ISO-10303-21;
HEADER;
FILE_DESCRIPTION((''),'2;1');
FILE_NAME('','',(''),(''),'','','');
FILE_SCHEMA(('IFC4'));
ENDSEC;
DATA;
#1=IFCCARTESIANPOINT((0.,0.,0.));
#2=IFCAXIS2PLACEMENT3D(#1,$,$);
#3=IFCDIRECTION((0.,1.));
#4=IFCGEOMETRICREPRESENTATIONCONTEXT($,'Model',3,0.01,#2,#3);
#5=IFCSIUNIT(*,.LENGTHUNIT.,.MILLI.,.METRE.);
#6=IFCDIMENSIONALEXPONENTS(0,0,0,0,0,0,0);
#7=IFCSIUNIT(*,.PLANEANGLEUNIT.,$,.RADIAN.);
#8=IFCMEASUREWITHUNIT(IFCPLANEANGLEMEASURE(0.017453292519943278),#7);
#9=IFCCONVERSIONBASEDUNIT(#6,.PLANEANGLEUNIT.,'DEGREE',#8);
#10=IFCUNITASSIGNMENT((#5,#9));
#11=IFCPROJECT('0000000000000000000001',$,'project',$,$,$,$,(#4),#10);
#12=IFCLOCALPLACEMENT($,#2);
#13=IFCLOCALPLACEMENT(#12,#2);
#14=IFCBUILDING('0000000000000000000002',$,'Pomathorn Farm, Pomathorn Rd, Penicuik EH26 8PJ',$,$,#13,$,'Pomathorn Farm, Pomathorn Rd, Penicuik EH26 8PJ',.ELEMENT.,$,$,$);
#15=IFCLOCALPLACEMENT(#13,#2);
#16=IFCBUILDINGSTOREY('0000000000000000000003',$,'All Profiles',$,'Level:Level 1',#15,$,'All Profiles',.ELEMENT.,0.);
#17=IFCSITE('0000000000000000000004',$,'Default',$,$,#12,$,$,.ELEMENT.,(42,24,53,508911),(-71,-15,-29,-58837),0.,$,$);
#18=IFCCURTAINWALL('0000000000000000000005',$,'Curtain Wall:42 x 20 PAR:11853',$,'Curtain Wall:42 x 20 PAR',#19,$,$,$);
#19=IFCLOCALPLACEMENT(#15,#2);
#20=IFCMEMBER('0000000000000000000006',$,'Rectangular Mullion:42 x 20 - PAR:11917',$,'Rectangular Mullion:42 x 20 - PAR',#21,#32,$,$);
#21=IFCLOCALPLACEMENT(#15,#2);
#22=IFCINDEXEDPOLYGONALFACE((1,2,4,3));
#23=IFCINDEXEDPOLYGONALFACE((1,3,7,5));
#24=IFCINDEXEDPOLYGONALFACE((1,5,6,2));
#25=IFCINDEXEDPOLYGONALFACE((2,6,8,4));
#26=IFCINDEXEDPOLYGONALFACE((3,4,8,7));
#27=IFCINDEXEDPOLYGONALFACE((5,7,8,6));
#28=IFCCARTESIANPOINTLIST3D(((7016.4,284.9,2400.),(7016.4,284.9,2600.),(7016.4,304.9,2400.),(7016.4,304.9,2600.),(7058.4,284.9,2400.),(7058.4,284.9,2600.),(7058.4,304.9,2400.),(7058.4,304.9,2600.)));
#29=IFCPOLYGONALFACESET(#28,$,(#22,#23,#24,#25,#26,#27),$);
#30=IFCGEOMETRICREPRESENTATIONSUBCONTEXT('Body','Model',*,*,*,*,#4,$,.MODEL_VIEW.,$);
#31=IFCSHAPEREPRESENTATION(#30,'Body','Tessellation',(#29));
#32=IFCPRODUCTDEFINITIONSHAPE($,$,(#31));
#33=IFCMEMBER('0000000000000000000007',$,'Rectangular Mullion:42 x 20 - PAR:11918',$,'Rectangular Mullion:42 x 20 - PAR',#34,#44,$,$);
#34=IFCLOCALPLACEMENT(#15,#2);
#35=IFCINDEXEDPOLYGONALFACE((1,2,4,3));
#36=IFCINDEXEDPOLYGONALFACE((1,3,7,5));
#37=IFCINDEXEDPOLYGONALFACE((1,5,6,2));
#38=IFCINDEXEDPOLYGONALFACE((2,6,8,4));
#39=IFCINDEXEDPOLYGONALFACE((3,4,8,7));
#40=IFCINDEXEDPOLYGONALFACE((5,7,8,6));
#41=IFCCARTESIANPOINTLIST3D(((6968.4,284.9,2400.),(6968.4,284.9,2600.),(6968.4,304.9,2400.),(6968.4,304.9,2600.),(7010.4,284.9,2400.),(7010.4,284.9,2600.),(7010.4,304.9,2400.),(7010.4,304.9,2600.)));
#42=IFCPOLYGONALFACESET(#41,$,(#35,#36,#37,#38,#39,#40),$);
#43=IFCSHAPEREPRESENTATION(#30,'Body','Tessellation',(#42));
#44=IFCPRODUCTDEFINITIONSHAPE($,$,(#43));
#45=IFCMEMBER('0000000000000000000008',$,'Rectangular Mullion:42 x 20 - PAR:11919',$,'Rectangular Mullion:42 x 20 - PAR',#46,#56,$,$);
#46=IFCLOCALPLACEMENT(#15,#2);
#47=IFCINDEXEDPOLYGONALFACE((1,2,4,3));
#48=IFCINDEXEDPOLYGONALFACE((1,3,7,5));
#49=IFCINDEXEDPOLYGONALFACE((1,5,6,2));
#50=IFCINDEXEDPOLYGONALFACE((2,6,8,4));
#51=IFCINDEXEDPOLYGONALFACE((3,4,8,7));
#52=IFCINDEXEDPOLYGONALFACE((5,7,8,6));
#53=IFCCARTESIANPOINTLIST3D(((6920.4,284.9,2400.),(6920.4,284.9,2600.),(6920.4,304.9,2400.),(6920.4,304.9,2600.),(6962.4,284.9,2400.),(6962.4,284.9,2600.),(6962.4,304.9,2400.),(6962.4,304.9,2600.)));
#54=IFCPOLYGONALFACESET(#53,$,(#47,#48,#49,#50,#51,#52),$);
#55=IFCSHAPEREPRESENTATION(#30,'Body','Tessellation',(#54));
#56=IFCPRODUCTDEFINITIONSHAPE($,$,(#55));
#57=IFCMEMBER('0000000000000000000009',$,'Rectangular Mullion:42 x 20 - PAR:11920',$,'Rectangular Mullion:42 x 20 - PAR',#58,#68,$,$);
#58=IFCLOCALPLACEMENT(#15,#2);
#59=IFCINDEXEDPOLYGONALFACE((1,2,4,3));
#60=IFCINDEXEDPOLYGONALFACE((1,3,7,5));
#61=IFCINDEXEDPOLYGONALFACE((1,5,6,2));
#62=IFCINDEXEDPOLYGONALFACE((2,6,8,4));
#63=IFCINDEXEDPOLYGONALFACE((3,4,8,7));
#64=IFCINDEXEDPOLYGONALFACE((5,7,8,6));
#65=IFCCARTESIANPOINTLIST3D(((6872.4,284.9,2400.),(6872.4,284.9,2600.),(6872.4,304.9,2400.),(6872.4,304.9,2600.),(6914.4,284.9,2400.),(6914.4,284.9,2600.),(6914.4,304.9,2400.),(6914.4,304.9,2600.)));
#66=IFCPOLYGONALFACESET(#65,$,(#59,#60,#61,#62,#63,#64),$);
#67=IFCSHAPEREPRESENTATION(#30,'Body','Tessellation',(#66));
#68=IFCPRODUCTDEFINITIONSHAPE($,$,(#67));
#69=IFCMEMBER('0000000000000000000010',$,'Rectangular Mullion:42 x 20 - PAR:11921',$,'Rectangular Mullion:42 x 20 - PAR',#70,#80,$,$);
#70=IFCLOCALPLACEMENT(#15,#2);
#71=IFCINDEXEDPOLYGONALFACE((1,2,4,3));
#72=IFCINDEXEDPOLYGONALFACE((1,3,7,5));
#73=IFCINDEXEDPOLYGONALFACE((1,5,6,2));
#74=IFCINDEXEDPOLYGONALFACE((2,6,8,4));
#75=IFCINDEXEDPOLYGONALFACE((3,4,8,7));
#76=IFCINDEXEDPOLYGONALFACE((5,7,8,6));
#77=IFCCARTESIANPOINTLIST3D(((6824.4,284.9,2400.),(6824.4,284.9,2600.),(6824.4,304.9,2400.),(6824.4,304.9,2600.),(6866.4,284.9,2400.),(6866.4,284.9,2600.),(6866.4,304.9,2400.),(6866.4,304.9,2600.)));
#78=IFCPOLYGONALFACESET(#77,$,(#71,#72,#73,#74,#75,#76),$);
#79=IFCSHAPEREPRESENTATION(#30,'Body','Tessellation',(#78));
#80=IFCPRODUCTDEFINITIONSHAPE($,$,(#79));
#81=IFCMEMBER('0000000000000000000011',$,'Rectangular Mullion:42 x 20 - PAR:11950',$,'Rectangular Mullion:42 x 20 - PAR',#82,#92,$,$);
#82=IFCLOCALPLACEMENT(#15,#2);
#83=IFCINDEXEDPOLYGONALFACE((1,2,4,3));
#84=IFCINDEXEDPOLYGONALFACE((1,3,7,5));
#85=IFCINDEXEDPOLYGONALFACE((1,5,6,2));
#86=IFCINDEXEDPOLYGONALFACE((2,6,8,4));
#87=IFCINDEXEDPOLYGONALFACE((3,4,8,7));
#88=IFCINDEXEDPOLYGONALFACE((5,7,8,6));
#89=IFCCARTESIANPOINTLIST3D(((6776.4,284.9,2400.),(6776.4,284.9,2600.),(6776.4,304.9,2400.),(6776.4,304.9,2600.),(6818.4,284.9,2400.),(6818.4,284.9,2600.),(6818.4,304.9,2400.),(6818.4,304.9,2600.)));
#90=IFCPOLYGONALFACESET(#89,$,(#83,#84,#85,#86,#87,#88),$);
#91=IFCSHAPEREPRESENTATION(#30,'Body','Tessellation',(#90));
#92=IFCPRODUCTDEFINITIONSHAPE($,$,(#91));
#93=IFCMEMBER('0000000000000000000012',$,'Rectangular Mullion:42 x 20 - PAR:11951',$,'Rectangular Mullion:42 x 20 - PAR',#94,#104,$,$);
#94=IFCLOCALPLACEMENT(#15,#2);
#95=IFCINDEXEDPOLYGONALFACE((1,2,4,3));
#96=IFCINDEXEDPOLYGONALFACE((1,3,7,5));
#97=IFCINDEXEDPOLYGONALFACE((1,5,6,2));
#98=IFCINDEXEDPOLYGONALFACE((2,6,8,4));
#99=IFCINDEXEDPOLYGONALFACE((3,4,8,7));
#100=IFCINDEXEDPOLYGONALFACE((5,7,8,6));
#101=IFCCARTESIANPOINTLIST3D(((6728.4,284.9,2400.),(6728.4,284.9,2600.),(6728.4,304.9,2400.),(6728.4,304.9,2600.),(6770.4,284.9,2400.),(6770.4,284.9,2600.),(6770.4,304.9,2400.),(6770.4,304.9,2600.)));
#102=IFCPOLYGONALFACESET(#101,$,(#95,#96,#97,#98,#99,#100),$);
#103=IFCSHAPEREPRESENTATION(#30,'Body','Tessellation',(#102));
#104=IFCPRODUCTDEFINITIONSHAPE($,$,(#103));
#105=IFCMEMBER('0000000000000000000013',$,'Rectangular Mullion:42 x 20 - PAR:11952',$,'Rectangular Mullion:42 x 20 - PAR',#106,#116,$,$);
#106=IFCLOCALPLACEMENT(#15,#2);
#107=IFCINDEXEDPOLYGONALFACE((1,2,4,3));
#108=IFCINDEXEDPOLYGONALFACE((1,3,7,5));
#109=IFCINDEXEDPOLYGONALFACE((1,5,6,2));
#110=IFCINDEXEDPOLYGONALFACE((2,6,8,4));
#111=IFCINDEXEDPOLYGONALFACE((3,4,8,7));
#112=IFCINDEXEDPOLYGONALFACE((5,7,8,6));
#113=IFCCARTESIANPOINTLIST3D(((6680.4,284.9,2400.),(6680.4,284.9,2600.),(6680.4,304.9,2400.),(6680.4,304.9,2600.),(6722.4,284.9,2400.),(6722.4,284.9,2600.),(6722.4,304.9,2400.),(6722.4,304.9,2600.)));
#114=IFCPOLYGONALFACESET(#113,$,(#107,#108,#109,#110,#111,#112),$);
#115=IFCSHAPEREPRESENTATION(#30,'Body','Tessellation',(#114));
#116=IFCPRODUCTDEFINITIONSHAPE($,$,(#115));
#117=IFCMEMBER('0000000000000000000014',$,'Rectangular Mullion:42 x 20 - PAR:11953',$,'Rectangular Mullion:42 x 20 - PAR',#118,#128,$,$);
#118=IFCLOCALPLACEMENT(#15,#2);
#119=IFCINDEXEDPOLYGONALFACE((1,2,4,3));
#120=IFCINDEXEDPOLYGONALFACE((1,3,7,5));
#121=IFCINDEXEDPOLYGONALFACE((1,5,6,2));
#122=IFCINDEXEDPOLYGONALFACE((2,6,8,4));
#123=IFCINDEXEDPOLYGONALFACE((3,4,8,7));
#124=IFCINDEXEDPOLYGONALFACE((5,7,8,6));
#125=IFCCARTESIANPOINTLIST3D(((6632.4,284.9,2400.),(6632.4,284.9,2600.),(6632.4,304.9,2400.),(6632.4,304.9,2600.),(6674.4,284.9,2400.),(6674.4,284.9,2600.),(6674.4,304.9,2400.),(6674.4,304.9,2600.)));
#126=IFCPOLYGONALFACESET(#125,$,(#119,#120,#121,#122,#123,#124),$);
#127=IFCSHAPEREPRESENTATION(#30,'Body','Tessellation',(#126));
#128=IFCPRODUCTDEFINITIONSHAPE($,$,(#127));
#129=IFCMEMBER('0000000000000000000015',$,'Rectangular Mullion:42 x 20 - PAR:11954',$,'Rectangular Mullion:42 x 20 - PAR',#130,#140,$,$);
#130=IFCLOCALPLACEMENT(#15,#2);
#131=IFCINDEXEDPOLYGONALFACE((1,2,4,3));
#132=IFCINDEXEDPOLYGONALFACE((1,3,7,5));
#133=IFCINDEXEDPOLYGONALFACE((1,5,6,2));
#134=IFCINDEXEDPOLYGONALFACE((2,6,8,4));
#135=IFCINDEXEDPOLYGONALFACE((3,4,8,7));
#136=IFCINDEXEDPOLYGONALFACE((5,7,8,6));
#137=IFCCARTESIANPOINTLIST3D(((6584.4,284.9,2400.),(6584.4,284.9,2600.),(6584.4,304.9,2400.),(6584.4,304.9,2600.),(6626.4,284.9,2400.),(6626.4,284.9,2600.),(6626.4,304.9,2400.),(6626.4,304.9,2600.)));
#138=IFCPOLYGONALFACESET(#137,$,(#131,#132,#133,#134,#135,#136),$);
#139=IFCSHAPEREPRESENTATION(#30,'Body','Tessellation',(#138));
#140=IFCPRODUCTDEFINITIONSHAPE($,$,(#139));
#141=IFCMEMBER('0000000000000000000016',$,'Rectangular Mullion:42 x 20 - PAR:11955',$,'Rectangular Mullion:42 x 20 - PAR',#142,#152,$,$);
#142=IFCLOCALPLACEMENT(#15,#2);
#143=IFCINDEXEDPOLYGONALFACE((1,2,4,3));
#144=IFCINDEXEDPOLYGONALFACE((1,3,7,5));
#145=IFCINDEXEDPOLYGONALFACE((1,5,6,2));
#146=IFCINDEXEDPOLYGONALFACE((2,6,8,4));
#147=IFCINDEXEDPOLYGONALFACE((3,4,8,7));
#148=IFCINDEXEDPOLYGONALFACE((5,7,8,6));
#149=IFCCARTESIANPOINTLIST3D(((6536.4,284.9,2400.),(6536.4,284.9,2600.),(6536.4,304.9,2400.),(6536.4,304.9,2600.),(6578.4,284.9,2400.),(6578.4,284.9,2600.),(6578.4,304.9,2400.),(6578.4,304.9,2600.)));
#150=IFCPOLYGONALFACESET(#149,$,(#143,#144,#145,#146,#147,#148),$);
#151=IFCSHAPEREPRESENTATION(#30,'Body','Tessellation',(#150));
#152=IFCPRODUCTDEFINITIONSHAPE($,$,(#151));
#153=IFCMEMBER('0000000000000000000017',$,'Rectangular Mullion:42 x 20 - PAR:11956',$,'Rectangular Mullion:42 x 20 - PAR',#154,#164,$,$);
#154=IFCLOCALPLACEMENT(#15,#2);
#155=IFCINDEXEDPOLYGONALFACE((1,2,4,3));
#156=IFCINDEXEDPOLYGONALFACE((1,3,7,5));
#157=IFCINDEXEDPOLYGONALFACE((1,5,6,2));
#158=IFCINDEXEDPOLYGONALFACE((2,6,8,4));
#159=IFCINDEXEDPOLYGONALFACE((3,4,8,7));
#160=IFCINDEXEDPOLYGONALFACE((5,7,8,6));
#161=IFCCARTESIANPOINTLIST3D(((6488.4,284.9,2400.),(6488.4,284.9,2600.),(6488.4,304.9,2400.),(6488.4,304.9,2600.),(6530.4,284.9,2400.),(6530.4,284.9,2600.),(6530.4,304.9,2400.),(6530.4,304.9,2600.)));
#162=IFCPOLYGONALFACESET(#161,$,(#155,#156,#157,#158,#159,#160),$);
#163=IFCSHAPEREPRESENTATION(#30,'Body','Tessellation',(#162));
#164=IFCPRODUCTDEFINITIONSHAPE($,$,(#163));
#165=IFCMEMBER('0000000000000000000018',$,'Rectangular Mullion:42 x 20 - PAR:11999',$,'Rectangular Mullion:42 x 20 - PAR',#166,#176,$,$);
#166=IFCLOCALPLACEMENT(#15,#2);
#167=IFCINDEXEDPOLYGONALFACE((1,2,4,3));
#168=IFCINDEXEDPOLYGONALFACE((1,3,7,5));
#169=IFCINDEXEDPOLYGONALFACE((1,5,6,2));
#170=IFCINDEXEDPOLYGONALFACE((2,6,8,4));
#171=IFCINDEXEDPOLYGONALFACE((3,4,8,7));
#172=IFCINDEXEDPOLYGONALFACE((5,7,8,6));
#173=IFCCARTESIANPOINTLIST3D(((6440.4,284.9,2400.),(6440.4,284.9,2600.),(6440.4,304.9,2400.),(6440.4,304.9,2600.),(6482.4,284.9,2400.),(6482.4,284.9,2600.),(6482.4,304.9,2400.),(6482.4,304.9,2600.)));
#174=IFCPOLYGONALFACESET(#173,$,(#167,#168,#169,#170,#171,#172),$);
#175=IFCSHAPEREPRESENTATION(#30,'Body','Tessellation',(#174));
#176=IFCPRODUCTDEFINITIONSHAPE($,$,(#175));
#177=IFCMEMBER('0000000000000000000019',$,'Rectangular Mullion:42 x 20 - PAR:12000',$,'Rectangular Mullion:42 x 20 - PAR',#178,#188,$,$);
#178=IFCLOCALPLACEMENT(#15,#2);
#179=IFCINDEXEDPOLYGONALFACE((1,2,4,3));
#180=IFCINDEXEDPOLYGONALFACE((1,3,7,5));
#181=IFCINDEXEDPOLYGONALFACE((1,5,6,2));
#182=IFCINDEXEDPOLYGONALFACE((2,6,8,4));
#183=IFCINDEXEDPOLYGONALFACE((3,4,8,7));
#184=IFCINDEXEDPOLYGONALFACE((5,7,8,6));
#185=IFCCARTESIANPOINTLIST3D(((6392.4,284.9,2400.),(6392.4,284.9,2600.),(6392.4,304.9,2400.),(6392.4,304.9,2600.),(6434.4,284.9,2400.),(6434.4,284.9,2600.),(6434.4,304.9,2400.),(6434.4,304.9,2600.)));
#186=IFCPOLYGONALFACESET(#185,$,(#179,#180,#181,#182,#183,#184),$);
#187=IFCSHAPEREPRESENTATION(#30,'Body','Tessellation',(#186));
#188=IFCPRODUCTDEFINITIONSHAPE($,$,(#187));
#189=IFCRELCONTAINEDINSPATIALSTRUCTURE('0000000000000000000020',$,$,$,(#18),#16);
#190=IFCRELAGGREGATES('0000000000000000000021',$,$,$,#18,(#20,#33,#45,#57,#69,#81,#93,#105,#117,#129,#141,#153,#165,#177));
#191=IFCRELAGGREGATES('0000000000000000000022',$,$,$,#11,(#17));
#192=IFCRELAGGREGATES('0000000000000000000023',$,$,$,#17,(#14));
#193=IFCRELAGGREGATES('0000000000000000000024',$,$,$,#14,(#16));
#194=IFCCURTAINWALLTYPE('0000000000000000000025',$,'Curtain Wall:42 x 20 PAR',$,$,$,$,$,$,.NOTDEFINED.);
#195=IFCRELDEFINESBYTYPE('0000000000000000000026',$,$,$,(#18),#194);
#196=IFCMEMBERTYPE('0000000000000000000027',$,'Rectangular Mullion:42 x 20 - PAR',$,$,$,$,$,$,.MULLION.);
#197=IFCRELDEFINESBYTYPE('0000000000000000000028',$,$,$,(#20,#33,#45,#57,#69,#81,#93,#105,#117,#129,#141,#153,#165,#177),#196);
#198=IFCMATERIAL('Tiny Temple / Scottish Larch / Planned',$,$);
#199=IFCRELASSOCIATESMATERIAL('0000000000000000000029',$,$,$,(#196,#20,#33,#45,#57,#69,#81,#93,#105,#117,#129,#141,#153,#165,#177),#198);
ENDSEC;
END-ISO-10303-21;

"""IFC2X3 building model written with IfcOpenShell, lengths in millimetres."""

from ifc_helpers import new_model, entity, si_unit, converted_unit, direction, frame, frame_2d, origin, place, context, subcontext, project, spatial, rectangle, extrude, source, transform, mapped, material, type_object, type_shapes, element, aggregate, save


model = new_model("IFC2X3")

# Units and contexts
model_context = context("Model", 3, precision=0.01, world=origin(), true_north=direction((0.0, 1.0)))
body_context = subcontext(model_context, "Body", "Model", "MODEL_VIEW")
ifc_project = project(units=[si_unit("LENGTHUNIT", "METRE", prefix="MILLI"), converted_unit("PLANEANGLEUNIT", "DEGREE", entity("IfcPlaneAngleMeasure", 0.017453292519943278), si_unit("PLANEANGLEUNIT", "RADIAN"), dimensions=[0, 0, 0, 0, 0, 0, 0])], contexts=[model_context])

# Site, building, storey
site_placement = place(None, origin())
site = spatial("IfcSite", under=ifc_project, at=site_placement, Name="Default", CompositionType="ELEMENT", RefLatitude=(42, 24, 53, 508911), RefLongitude=(-71, -15, -29, -58837), RefElevation=0.0)
building_placement = place(site_placement, origin())
building = spatial("IfcBuilding", under=site, at=building_placement, Name="Pomathorn Farm, Pomathorn Rd, Penicuik EH26 8PJ", LongName="Pomathorn Farm, Pomathorn Rd, Penicuik EH26 8PJ", CompositionType="ELEMENT")
storey_placement = place(building_placement, origin())
storey = spatial("IfcBuildingStorey", under=building, at=storey_placement, Name="All Profiles", ObjectType="Level:Level 1", LongName="All Profiles", CompositionType="ELEMENT", Elevation=0.0)

# Curtain wall, members
curtain_wall_type = type_object("IfcCurtainWallType", Name="Curtain Wall:42 x 20 PAR", PredefinedType="NOTDEFINED")
curtain_wall_placement = place(storey_placement, origin())
curtain_wall = element("IfcCurtainWall", 1, at=curtain_wall_placement, inside=storey, type_object=curtain_wall_type, Name="Curtain Wall:42 x 20 PAR:11853", ObjectType="Curtain Wall:42 x 20 PAR")
ifc_material = material(Name="Tiny Temple / Scottish Larch / Planned")
member_type = type_object("IfcMemberType", Name="Rectangular Mullion:42 x 20 - PAR", PredefinedType="MULLION", material=ifc_material)
shared_shape = source(origin(), body_context, "Body", "SweptSolid", [
    extrude(rectangle(XDim=20.0, YDim=42.0, at=frame_2d((0.0, 0.0), x_axis=(1.0, 0.0))), frame((-21.0, -10.0, -200.0), z_axis=(0.0, 0.0, 1.0), x_axis=(0.0, 1.0, 0.0)), (0.0, 0.0, 1.0), 200.0),
])
type_shapes(member_type, [shared_shape])
member_1_placement = place(curtain_wall_placement, frame((7058.4, 284.9, 2400.0), z_axis=(0.0, 0.0, -1.0), x_axis=(1.0, 0.0, 0.0)))
member_1 = element("IfcMember", 2, at=member_1_placement, type_object=member_type, material=ifc_material, Name="Rectangular Mullion:42 x 20 - PAR:11917", ObjectType="Rectangular Mullion:42 x 20 - PAR", context=body_context, shape_type="MappedRepresentation", body=[
    mapped(shared_shape, transform((0.0, 0.0, 0.0), scale=1.0)),
])
member_2_placement = place(curtain_wall_placement, frame((7010.4, 284.9, 2400.0), z_axis=(0.0, 0.0, -1.0), x_axis=(1.0, 0.0, 0.0)))
member_2 = element("IfcMember", 3, at=member_2_placement, type_object=member_type, material=ifc_material, Name="Rectangular Mullion:42 x 20 - PAR:11918", ObjectType="Rectangular Mullion:42 x 20 - PAR", context=body_context, shape_type="MappedRepresentation", body=[
    mapped(shared_shape, transform((0.0, 0.0, 0.0), scale=1.0)),
])
member_3_placement = place(curtain_wall_placement, frame((6962.4, 284.9, 2400.0), z_axis=(0.0, 0.0, -1.0), x_axis=(1.0, 0.0, 0.0)))
member_3 = element("IfcMember", 4, at=member_3_placement, type_object=member_type, material=ifc_material, Name="Rectangular Mullion:42 x 20 - PAR:11919", ObjectType="Rectangular Mullion:42 x 20 - PAR", context=body_context, shape_type="MappedRepresentation", body=[
    mapped(shared_shape, transform((0.0, 0.0, 0.0), scale=1.0)),
])
member_4_placement = place(curtain_wall_placement, frame((6914.4, 284.9, 2400.0), z_axis=(0.0, 0.0, -1.0), x_axis=(1.0, 0.0, 0.0)))
member_4 = element("IfcMember", 5, at=member_4_placement, type_object=member_type, material=ifc_material, Name="Rectangular Mullion:42 x 20 - PAR:11920", ObjectType="Rectangular Mullion:42 x 20 - PAR", context=body_context, shape_type="MappedRepresentation", body=[
    mapped(shared_shape, transform((0.0, 0.0, 0.0), scale=1.0)),
])
member_5_placement = place(curtain_wall_placement, frame((6866.4, 284.9, 2400.0), z_axis=(0.0, 0.0, -1.0), x_axis=(1.0, 0.0, 0.0)))
member_5 = element("IfcMember", 6, at=member_5_placement, type_object=member_type, material=ifc_material, Name="Rectangular Mullion:42 x 20 - PAR:11921", ObjectType="Rectangular Mullion:42 x 20 - PAR", context=body_context, shape_type="MappedRepresentation", body=[
    mapped(shared_shape, transform((0.0, 0.0, 0.0), scale=1.0)),
])
member_6_placement = place(curtain_wall_placement, frame((6818.4, 284.9, 2400.0), z_axis=(0.0, 0.0, -1.0), x_axis=(1.0, 0.0, 0.0)))
member_6 = element("IfcMember", 7, at=member_6_placement, type_object=member_type, material=ifc_material, Name="Rectangular Mullion:42 x 20 - PAR:11950", ObjectType="Rectangular Mullion:42 x 20 - PAR", context=body_context, shape_type="MappedRepresentation", body=[
    mapped(shared_shape, transform((0.0, 0.0, 0.0), scale=1.0)),
])
member_7_placement = place(curtain_wall_placement, frame((6770.4, 284.9, 2400.0), z_axis=(0.0, 0.0, -1.0), x_axis=(1.0, 0.0, 0.0)))
member_7 = element("IfcMember", 8, at=member_7_placement, type_object=member_type, material=ifc_material, Name="Rectangular Mullion:42 x 20 - PAR:11951", ObjectType="Rectangular Mullion:42 x 20 - PAR", context=body_context, shape_type="MappedRepresentation", body=[
    mapped(shared_shape, transform((0.0, 0.0, 0.0), scale=1.0)),
])
member_8_placement = place(curtain_wall_placement, frame((6722.4, 284.9, 2400.0), z_axis=(0.0, 0.0, -1.0), x_axis=(1.0, 0.0, 0.0)))
member_8 = element("IfcMember", 9, at=member_8_placement, type_object=member_type, material=ifc_material, Name="Rectangular Mullion:42 x 20 - PAR:11952", ObjectType="Rectangular Mullion:42 x 20 - PAR", context=body_context, shape_type="MappedRepresentation", body=[
    mapped(shared_shape, transform((0.0, 0.0, 0.0), scale=1.0)),
])
member_9_placement = place(curtain_wall_placement, frame((6674.4, 284.9, 2400.0), z_axis=(0.0, 0.0, -1.0), x_axis=(1.0, 0.0, 0.0)))
member_9 = element("IfcMember", 10, at=member_9_placement, type_object=member_type, material=ifc_material, Name="Rectangular Mullion:42 x 20 - PAR:11953", ObjectType="Rectangular Mullion:42 x 20 - PAR", context=body_context, shape_type="MappedRepresentation", body=[
    mapped(shared_shape, transform((0.0, 0.0, 0.0), scale=1.0)),
])
member_10_placement = place(curtain_wall_placement, frame((6626.4, 284.9, 2400.0), z_axis=(0.0, 0.0, -1.0), x_axis=(1.0, 0.0, 0.0)))
member_10 = element("IfcMember", 11, at=member_10_placement, type_object=member_type, material=ifc_material, Name="Rectangular Mullion:42 x 20 - PAR:11954", ObjectType="Rectangular Mullion:42 x 20 - PAR", context=body_context, shape_type="MappedRepresentation", body=[
    mapped(shared_shape, transform((0.0, 0.0, 0.0), scale=1.0)),
])
member_11_placement = place(curtain_wall_placement, frame((6578.4, 284.9, 2400.0), z_axis=(0.0, 0.0, -1.0), x_axis=(1.0, 0.0, 0.0)))
member_11 = element("IfcMember", 12, at=member_11_placement, type_object=member_type, material=ifc_material, Name="Rectangular Mullion:42 x 20 - PAR:11955", ObjectType="Rectangular Mullion:42 x 20 - PAR", context=body_context, shape_type="MappedRepresentation", body=[
    mapped(shared_shape, transform((0.0, 0.0, 0.0), scale=1.0)),
])
member_12_placement = place(curtain_wall_placement, frame((6530.4, 284.9, 2400.0), z_axis=(0.0, 0.0, -1.0), x_axis=(1.0, 0.0, 0.0)))
member_12 = element("IfcMember", 13, at=member_12_placement, type_object=member_type, material=ifc_material, Name="Rectangular Mullion:42 x 20 - PAR:11956", ObjectType="Rectangular Mullion:42 x 20 - PAR", context=body_context, shape_type="MappedRepresentation", body=[
    mapped(shared_shape, transform((0.0, 0.0, 0.0), scale=1.0)),
])
member_13_placement = place(curtain_wall_placement, frame((6482.4, 284.9, 2400.0), z_axis=(0.0, 0.0, -1.0), x_axis=(1.0, 0.0, 0.0)))
member_13 = element("IfcMember", 14, at=member_13_placement, type_object=member_type, material=ifc_material, Name="Rectangular Mullion:42 x 20 - PAR:11999", ObjectType="Rectangular Mullion:42 x 20 - PAR", context=body_context, shape_type="MappedRepresentation", body=[
    mapped(shared_shape, transform((0.0, 0.0, 0.0), scale=1.0)),
])
member_14_placement = place(curtain_wall_placement, frame((6434.4, 284.9, 2400.0), z_axis=(0.0, 0.0, -1.0), x_axis=(1.0, 0.0, 0.0)))
member_14 = element("IfcMember", 15, at=member_14_placement, type_object=member_type, material=ifc_material, Name="Rectangular Mullion:42 x 20 - PAR:12000", ObjectType="Rectangular Mullion:42 x 20 - PAR", context=body_context, shape_type="MappedRepresentation", body=[
    mapped(shared_shape, transform((0.0, 0.0, 0.0), scale=1.0)),
])
aggregate(curtain_wall, [member_1, member_2, member_3, member_4, member_5, member_6, member_7, member_8, member_9, member_10, member_11, member_12, member_13, member_14])

save(model, "model.ifc")
